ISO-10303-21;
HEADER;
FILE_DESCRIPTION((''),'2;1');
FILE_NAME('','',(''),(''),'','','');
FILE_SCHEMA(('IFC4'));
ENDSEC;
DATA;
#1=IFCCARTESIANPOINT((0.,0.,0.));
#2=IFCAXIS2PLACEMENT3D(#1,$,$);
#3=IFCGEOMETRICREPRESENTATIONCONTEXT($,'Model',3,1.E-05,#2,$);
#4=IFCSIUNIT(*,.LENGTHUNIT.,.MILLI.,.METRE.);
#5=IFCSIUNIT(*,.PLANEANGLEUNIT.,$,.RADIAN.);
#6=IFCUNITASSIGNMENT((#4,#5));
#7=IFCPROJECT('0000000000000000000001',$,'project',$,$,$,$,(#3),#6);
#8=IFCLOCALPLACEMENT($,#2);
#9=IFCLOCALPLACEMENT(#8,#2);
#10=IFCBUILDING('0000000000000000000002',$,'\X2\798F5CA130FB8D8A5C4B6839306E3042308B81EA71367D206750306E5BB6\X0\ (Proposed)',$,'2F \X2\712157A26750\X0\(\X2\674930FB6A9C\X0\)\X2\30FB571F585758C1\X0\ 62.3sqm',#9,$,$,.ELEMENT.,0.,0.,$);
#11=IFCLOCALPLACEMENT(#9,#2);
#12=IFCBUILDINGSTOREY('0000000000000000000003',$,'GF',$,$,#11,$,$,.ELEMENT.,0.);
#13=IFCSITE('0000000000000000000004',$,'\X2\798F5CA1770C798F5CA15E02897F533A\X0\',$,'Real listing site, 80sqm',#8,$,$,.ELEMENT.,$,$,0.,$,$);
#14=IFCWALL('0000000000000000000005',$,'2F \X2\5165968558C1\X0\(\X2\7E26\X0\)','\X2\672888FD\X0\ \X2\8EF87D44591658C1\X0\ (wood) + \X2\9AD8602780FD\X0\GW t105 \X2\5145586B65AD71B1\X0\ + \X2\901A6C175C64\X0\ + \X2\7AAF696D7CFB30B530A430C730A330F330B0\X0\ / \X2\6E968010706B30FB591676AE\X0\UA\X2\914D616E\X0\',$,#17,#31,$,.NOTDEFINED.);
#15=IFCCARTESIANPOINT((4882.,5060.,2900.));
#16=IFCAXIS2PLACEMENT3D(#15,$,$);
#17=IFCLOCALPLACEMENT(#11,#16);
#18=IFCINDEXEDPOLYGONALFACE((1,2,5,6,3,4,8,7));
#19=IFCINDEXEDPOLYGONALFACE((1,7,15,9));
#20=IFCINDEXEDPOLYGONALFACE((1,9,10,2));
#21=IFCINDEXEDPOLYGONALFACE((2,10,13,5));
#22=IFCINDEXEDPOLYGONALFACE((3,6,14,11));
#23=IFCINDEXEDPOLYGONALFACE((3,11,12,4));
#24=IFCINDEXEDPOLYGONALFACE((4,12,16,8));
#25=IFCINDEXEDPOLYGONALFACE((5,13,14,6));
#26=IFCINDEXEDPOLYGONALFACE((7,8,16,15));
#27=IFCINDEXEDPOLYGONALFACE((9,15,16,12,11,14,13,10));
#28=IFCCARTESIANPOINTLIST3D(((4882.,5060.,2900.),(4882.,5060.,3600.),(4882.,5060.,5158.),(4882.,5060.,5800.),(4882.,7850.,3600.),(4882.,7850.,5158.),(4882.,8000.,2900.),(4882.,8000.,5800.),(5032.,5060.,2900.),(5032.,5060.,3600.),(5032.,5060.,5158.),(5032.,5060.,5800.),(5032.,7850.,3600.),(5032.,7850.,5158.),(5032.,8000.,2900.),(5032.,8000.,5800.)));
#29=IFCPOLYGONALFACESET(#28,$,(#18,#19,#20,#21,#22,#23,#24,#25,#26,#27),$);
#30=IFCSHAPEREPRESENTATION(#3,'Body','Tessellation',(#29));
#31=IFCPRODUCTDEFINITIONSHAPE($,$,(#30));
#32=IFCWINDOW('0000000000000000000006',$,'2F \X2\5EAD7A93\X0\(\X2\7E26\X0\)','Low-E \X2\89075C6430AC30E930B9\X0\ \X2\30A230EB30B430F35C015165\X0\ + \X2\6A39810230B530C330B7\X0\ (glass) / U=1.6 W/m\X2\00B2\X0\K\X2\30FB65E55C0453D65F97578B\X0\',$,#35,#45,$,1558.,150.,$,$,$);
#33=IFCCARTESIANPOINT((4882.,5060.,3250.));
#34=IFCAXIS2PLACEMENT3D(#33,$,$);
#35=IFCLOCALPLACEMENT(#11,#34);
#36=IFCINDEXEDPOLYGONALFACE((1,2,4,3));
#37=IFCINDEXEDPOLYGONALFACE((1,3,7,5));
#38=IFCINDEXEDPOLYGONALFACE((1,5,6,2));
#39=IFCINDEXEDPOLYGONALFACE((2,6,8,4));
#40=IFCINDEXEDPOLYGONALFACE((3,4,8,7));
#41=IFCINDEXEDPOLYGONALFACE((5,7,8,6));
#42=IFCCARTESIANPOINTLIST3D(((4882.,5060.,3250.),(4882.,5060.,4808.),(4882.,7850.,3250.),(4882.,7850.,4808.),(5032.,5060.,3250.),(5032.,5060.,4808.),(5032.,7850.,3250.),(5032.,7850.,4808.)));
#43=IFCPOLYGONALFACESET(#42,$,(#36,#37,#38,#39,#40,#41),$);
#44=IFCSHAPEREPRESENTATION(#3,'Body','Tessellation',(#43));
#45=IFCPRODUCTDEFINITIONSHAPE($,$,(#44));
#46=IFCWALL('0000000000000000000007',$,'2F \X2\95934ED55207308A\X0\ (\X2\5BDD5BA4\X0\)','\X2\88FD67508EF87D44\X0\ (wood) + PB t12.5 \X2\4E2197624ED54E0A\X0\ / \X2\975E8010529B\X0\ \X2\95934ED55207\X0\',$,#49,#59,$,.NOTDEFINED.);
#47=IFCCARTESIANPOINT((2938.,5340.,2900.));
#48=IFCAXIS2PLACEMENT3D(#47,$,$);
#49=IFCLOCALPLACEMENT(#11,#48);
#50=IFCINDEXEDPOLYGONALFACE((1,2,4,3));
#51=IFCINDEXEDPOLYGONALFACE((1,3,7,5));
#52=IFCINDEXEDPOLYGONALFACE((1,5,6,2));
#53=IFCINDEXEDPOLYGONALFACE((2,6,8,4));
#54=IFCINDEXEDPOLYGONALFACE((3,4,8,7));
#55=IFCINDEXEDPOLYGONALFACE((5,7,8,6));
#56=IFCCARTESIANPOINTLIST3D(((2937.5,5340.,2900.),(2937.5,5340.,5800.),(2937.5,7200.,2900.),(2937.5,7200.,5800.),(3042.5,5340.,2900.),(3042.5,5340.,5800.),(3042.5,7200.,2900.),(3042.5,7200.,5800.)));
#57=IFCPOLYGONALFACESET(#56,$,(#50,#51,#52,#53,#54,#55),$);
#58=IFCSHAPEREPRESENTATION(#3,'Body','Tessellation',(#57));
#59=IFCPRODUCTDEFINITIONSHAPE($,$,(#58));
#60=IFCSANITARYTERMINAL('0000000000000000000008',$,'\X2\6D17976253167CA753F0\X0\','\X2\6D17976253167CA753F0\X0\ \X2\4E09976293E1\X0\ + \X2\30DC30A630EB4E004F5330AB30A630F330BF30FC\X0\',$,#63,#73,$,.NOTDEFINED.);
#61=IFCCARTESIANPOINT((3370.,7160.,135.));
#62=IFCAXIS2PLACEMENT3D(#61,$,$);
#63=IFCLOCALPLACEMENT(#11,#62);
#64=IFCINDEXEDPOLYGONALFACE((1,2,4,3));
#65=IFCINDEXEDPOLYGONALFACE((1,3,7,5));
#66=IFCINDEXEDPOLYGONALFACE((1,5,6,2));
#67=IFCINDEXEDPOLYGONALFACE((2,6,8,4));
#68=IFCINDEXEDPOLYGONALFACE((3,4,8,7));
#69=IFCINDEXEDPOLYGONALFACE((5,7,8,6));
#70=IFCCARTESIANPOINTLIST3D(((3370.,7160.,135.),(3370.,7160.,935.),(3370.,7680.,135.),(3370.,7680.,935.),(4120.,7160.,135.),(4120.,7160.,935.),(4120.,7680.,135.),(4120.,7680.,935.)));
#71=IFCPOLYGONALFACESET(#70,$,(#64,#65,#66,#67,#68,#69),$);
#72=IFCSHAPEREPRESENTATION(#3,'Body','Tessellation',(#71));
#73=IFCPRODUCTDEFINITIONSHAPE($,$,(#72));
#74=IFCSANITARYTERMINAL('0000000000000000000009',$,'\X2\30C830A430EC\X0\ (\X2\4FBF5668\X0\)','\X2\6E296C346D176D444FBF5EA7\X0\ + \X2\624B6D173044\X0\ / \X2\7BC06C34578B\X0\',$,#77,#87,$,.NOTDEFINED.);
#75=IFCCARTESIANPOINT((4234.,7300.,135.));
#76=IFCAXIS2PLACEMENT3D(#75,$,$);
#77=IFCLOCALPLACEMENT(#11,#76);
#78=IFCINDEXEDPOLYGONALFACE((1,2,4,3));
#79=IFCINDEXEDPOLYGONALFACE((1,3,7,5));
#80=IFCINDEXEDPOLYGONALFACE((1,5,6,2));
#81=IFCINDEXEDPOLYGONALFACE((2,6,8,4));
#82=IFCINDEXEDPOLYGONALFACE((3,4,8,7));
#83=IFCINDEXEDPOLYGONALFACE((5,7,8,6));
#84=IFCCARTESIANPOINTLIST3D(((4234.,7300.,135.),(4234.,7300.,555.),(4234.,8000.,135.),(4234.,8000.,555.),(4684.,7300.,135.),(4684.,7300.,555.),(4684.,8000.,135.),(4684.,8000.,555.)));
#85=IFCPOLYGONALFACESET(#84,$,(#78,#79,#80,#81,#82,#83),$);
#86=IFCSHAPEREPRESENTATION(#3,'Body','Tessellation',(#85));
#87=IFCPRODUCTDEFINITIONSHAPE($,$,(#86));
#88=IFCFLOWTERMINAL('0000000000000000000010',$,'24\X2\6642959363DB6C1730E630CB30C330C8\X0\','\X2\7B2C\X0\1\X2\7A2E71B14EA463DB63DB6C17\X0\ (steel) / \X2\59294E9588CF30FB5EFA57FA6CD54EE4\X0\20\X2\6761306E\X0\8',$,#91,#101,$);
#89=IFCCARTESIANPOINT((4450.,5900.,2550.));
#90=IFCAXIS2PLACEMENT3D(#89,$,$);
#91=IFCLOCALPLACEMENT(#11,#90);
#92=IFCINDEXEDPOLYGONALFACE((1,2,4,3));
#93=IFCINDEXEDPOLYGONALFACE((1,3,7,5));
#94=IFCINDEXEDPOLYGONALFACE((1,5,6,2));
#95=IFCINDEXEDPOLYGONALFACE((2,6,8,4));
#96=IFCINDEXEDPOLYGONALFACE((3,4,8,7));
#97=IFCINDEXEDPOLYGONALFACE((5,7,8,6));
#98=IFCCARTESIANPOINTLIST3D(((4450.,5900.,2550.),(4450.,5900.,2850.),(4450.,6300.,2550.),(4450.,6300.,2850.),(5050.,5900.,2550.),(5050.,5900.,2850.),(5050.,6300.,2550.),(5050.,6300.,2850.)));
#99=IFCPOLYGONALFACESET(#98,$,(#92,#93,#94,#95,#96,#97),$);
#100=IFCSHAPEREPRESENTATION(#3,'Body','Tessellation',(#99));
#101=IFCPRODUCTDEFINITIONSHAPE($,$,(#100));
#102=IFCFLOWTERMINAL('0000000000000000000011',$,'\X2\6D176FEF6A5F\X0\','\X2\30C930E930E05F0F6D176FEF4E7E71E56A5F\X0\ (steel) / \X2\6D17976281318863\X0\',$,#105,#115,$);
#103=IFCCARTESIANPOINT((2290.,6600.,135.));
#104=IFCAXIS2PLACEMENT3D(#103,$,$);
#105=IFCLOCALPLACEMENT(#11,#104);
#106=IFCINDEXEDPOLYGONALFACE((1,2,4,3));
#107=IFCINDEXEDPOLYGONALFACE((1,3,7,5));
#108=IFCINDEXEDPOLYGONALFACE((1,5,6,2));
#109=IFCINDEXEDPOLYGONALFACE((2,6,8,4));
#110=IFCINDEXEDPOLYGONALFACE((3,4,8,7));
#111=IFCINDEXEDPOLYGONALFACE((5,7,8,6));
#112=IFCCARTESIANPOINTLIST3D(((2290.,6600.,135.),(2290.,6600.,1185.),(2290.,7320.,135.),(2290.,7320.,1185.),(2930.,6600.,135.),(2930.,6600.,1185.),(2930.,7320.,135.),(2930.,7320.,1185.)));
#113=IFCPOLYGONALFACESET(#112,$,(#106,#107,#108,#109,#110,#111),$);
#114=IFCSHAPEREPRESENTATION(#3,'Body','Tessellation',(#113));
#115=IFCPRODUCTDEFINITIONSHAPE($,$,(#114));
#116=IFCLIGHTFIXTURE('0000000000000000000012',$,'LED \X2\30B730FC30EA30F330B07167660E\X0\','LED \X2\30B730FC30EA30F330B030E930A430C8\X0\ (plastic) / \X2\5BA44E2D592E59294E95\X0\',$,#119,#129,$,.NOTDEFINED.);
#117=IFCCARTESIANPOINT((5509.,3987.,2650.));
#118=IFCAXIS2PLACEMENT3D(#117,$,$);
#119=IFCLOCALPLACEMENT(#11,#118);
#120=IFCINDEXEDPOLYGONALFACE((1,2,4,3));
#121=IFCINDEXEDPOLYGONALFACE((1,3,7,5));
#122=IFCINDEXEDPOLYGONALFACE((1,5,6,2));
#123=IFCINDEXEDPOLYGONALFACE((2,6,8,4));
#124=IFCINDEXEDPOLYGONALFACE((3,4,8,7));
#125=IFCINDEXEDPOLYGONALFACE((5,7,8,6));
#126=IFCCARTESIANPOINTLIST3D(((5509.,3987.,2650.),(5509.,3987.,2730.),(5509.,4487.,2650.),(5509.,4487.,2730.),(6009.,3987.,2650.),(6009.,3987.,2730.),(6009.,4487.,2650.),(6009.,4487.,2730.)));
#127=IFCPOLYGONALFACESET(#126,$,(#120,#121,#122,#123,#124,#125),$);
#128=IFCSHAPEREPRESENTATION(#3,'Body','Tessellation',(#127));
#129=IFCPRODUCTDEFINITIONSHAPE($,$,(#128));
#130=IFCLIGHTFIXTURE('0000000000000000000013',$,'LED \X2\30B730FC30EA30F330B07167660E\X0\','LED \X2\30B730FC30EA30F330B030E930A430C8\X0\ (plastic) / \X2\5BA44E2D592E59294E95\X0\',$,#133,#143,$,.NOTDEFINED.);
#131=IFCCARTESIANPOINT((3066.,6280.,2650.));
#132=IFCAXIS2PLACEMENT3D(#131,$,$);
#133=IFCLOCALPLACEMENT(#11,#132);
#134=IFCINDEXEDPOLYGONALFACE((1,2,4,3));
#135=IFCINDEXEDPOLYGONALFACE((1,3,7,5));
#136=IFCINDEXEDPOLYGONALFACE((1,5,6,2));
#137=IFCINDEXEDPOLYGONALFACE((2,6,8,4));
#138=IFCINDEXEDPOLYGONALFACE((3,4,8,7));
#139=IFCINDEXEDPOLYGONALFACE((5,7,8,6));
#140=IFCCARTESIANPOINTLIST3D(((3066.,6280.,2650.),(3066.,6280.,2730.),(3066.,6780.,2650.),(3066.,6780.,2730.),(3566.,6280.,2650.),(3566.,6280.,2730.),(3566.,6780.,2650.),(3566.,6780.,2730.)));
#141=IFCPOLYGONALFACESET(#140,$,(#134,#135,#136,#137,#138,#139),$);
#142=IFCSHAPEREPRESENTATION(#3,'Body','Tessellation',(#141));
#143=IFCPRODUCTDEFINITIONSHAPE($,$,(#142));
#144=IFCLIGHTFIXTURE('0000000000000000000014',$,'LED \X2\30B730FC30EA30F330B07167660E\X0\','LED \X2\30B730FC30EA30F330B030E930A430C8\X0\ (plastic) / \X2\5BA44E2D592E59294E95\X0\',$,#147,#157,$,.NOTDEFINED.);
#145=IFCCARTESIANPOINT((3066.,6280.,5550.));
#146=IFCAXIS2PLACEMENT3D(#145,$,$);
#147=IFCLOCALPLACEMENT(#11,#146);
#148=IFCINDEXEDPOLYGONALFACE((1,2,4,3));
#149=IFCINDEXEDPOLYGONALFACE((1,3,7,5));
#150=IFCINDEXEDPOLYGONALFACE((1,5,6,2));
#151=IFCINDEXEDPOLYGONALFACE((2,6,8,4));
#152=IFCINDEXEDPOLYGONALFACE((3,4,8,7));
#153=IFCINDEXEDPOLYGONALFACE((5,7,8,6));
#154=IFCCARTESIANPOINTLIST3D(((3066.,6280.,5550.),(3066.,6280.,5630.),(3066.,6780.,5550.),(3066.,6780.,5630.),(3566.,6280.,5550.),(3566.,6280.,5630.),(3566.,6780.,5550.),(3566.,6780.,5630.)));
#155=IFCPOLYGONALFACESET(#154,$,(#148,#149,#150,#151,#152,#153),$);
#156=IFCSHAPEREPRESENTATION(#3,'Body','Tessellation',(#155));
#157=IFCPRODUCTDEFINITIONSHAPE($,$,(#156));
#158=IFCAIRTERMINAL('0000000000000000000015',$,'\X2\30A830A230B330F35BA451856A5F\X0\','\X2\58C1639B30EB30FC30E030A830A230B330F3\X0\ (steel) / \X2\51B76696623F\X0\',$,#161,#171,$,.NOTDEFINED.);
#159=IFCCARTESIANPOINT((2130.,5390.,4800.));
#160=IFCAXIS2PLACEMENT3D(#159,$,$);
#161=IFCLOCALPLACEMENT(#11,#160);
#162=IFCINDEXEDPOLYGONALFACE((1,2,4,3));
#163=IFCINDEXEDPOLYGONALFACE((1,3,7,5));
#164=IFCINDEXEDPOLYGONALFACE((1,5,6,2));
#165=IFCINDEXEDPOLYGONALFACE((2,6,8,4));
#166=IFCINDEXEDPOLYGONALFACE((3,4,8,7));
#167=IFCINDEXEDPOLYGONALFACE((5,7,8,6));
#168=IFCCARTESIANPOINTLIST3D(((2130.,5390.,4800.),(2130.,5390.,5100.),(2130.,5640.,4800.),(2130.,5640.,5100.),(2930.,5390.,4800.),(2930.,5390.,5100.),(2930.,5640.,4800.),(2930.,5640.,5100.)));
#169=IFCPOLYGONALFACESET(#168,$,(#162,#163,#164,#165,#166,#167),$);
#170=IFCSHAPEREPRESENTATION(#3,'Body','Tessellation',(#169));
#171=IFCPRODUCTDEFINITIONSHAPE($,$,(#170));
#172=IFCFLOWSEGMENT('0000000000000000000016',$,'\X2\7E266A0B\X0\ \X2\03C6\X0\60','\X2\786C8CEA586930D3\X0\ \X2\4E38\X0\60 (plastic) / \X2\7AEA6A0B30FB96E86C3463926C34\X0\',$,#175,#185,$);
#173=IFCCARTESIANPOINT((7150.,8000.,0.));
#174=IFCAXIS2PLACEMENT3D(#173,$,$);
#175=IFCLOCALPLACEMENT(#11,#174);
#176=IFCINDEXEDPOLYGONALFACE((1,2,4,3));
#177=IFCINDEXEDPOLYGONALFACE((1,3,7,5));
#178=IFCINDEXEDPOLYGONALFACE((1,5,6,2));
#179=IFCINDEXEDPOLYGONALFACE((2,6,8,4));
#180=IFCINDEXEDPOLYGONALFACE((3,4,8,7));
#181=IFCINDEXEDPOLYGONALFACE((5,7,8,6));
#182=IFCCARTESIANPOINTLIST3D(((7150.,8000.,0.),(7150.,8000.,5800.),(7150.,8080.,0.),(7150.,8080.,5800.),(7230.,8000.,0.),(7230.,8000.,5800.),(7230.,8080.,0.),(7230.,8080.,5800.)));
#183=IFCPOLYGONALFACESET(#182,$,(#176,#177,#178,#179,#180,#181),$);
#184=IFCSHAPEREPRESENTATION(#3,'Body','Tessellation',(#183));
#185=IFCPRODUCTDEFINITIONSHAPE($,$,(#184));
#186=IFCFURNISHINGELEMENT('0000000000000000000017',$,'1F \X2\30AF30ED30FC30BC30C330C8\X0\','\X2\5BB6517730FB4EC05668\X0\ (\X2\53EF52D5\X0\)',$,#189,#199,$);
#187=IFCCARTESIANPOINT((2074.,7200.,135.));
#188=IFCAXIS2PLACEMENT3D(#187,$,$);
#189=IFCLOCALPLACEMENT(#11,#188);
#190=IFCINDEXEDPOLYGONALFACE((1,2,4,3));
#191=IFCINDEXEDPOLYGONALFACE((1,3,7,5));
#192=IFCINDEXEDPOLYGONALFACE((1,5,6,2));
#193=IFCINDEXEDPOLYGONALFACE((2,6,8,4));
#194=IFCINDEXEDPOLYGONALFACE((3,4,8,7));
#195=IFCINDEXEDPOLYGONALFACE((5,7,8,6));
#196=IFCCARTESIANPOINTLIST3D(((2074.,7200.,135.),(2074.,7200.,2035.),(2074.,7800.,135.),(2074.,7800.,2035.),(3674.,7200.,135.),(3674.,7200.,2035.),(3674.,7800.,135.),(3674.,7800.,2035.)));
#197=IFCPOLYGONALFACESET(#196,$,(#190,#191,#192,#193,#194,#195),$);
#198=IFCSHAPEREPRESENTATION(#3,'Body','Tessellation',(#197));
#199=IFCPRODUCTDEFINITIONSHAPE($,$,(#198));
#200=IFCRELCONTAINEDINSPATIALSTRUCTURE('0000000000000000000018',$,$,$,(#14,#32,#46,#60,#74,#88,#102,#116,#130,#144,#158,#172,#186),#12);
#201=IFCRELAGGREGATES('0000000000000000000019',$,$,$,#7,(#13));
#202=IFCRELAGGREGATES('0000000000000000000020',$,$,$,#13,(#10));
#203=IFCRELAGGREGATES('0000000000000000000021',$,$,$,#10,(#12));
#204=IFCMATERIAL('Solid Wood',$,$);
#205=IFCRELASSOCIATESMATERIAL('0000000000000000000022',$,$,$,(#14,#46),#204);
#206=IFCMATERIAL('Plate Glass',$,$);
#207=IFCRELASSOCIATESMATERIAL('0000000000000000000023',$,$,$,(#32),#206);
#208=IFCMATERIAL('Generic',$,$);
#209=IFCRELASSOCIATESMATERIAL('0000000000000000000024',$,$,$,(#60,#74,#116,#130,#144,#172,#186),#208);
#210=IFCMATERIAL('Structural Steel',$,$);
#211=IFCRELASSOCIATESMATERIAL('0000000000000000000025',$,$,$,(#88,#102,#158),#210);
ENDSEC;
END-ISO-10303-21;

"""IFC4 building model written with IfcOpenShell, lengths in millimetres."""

from ifc_helpers import new_model, si_unit, frame, frame_2d, origin, place, context, project, spatial, rectangle, extrude, material, element, fill, save


model = new_model("IFC4")

# Units and contexts
model_context = context("Model", 3, precision=1e-05, world=origin())
ifc_project = project(units=[si_unit("LENGTHUNIT", "METRE", prefix="MILLI"), si_unit("PLANEANGLEUNIT", "RADIAN")], contexts=[model_context])

# Site, building, storey
site_placement = place(None, origin())
site = spatial("IfcSite", under=ifc_project, at=site_placement, Name="福岡県福岡市西区", ObjectType="Real listing site, 80sqm", CompositionType="ELEMENT", RefElevation=0.0)
building_placement = place(site_placement, origin())
building = spatial("IfcBuilding", under=site, at=building_placement, Name="福岡・越屋根のある自然素材の家 (Proposed)", ObjectType="2F 無垢材(杉・檜)・土塗壁 62.3sqm", CompositionType="ELEMENT", ElevationOfRefHeight=0.0, ElevationOfTerrain=0.0)
storey_placement = place(building_placement, origin())
storey = spatial("IfcBuildingStorey", under=building, at=storey_placement, Name="GF", CompositionType="ELEMENT", Elevation=0.0)

# Shared definitions
ifc_material_1 = material(Name="Solid Wood")

# Shared definitions
ifc_material_2 = material(Name="Plate Glass")

# Wall, opening, window
wall_1_placement = place(storey_placement, frame((4882.0, 5060.0, 2900.0)))
wall_1 = element("IfcWall", 1, at=wall_1_placement, inside=storey, material=ifc_material_1, Name="2F 入隅壁(縦)", Description="木製 軸組外壁 (wood) + 高性能GW t105 充填断熱 + 通気層 + 窯業系サイディング / 準耐火・外皮UA配慮", PredefinedType="NOTDEFINED", context=model_context, shape_type="SweptSolid", body=[
    extrude(rectangle(XDim=150.0, YDim=2940.0, at=frame_2d((75.0, 1470.0))), frame((4882.0, 5060.0, 2900.0)), (0.0, 0.0, 1.0), 2900.0),
])
opening_1_placement = place(storey_placement, frame((4882.0, 5060.0, 3250.0)))
opening_1 = element("IfcOpeningElement", 2, at=opening_1_placement, cuts=wall_1, PredefinedType="NOTDEFINED", context=model_context, shape_type="SweptSolid", body=[
    extrude(rectangle(XDim=150.0, YDim=2790.0, at=frame_2d((75.0, 1395.0))), frame((4882.0, 5060.0, 3250.0)), (0.0, 0.0, 1.0), 1558.0),
])
window_1_placement = place(storey_placement, frame((4882.0, 5060.0, 3250.0)))
window_1 = element("IfcWindow", 3, at=window_1_placement, inside=storey, material=ifc_material_2, Name="2F 庭窓(縦)", Description="Low-E 複層ガラス アルゴン封入 + 樹脂サッシ (glass) / U=1.6 W/m²K・日射取得型", OverallHeight=1558.0, OverallWidth=150.0, context=model_context, shape_type="SweptSolid", body=[
    extrude(rectangle(XDim=150.0, YDim=2790.0, at=frame_2d((75.0, 1395.0))), frame((4882.0, 5060.0, 3250.0)), (0.0, 0.0, 1.0), 1558.0),
])
fill(opening_1, window_1)

# Wall
wall_2_placement = place(storey_placement, frame((2938.0, 5340.0, 2900.0)))
element("IfcWall", 4, at=wall_2_placement, inside=storey, material=ifc_material_1, Name="2F 間仕切り (寝室)", Description="製材軸組 (wood) + PB t12.5 両面仕上 / 非耐力 間仕切", PredefinedType="NOTDEFINED", context=model_context, shape_type="SweptSolid", body=[
    extrude(rectangle(XDim=105.0, YDim=1860.0, at=frame_2d((52.0, 930.0))), frame((2938.0, 5340.0, 2900.0)), (0.0, 0.0, 1.0), 2900.0),
])

# Sanitary terminals
ifc_material_3 = material(Name="Generic")
sanitary_terminal_1_placement = place(storey_placement, frame((3370.0, 7160.0, 135.0)))
element("IfcSanitaryTerminal", 5, at=sanitary_terminal_1_placement, inside=storey, material=ifc_material_3, Name="洗面化粧台", Description="洗面化粧台 三面鏡 + ボウル一体カウンター", PredefinedType="NOTDEFINED", context=model_context, shape_type="SweptSolid", body=[
    extrude(rectangle(XDim=750.0, YDim=520.0, at=frame_2d((375.0, 260.0))), frame((3370.0, 7160.0, 135.0)), (0.0, 0.0, 1.0), 800.0),
])
sanitary_terminal_2_placement = place(storey_placement, frame((4234.0, 7300.0, 135.0)))
element("IfcSanitaryTerminal", 6, at=sanitary_terminal_2_placement, inside=storey, material=ifc_material_3, Name="トイレ (便器)", Description="温水洗浄便座 + 手洗い / 節水型", PredefinedType="NOTDEFINED", context=model_context, shape_type="SweptSolid", body=[
    extrude(rectangle(XDim=450.0, YDim=700.0, at=frame_2d((225.0, 350.0))), frame((4234.0, 7300.0, 135.0)), (0.0, 0.0, 1.0), 420.0),
])

# Flow terminals
ifc_material_4 = material(Name="Structural Steel")
flow_terminal_1_placement = place(storey_placement, frame((4450.0, 5900.0, 2550.0)))
element("IfcFlowTerminal", 7, at=flow_terminal_1_placement, inside=storey, material=ifc_material_4, Name="24時間換気ユニット", Description="第1種熱交換換気 (steel) / 天井裏・建基法令20条の8", context=model_context, shape_type="SweptSolid", body=[
    extrude(rectangle(XDim=600.0, YDim=400.0, at=frame_2d((300.0, 200.0))), frame((4450.0, 5900.0, 2550.0)), (0.0, 0.0, 1.0), 300.0),
])
flow_terminal_2_placement = place(storey_placement, frame((2290.0, 6600.0, 135.0)))
element("IfcFlowTerminal", 8, at=flow_terminal_2_placement, inside=storey, material=ifc_material_4, Name="洗濯機", Description="ドラム式洗濯乾燥機 (steel) / 洗面脱衣", context=model_context, shape_type="SweptSolid", body=[
    extrude(rectangle(XDim=640.0, YDim=720.0, at=frame_2d((320.0, 360.0))), frame((2290.0, 6600.0, 135.0)), (0.0, 0.0, 1.0), 1050.0),
])

# Light fixtures
light_fixture_1_placement = place(storey_placement, frame((5509.0, 3987.0, 2650.0)))
element("IfcLightFixture", 9, at=light_fixture_1_placement, inside=storey, material=ifc_material_3, Name="LED シーリング照明", Description="LED シーリングライト (plastic) / 室中央天井", PredefinedType="NOTDEFINED", context=model_context, shape_type="SweptSolid", body=[
    extrude(rectangle(XDim=500.0, YDim=500.0, at=frame_2d((250.0, 250.0))), frame((5509.0, 3987.0, 2650.0)), (0.0, 0.0, 1.0), 80.0),
])
light_fixture_2_placement = place(storey_placement, frame((3066.0, 6280.0, 2650.0)))
element("IfcLightFixture", 10, at=light_fixture_2_placement, inside=storey, material=ifc_material_3, Name="LED シーリング照明", Description="LED シーリングライト (plastic) / 室中央天井", PredefinedType="NOTDEFINED", context=model_context, shape_type="SweptSolid", body=[
    extrude(rectangle(XDim=500.0, YDim=500.0, at=frame_2d((250.0, 250.0))), frame((3066.0, 6280.0, 2650.0)), (0.0, 0.0, 1.0), 80.0),
])
light_fixture_3_placement = place(storey_placement, frame((3066.0, 6280.0, 5550.0)))
element("IfcLightFixture", 11, at=light_fixture_3_placement, inside=storey, material=ifc_material_3, Name="LED シーリング照明", Description="LED シーリングライト (plastic) / 室中央天井", PredefinedType="NOTDEFINED", context=model_context, shape_type="SweptSolid", body=[
    extrude(rectangle(XDim=500.0, YDim=500.0, at=frame_2d((250.0, 250.0))), frame((3066.0, 6280.0, 5550.0)), (0.0, 0.0, 1.0), 80.0),
])

# Air terminal
air_terminal_placement = place(storey_placement, frame((2130.0, 5390.0, 4800.0)))
element("IfcAirTerminal", 12, at=air_terminal_placement, inside=storey, material=ifc_material_4, Name="エアコン室内機", Description="壁掛ルームエアコン (steel) / 冷暖房", PredefinedType="NOTDEFINED", context=model_context, shape_type="SweptSolid", body=[
    extrude(rectangle(XDim=800.0, YDim=250.0, at=frame_2d((400.0, 125.0))), frame((2130.0, 5390.0, 4800.0)), (0.0, 0.0, 1.0), 300.0),
])

# Flow segment
flow_segment_placement = place(storey_placement, frame((7150.0, 8000.0, 0.0)))
element("IfcFlowSegment", 13, at=flow_segment_placement, inside=storey, material=ifc_material_3, Name="縦樋 φ60", Description="硬質塩ビ 丸60 (plastic) / 竪樋・雨水排水", context=model_context, shape_type="SweptSolid", body=[
    extrude(rectangle(XDim=80.0, YDim=80.0, at=frame_2d((40.0, 40.0))), frame((7150.0, 8000.0, 0.0)), (0.0, 0.0, 1.0), 5800.0),
])

# Furnishing element
furnishing_1_placement = place(storey_placement, frame((2074.0, 7200.0, 135.0)))
element("IfcFurnishingElement", 14, at=furnishing_1_placement, inside=storey, material=ifc_material_3, Name="1F クローゼット", Description="家具・什器 (可動)", context=model_context, shape_type="SweptSolid", body=[
    extrude(rectangle(XDim=1600.0, YDim=600.0, at=frame_2d((800.0, 300.0))), frame((2074.0, 7200.0, 135.0)), (0.0, 0.0, 1.0), 1900.0),
])

save(model, "model.ifc")
